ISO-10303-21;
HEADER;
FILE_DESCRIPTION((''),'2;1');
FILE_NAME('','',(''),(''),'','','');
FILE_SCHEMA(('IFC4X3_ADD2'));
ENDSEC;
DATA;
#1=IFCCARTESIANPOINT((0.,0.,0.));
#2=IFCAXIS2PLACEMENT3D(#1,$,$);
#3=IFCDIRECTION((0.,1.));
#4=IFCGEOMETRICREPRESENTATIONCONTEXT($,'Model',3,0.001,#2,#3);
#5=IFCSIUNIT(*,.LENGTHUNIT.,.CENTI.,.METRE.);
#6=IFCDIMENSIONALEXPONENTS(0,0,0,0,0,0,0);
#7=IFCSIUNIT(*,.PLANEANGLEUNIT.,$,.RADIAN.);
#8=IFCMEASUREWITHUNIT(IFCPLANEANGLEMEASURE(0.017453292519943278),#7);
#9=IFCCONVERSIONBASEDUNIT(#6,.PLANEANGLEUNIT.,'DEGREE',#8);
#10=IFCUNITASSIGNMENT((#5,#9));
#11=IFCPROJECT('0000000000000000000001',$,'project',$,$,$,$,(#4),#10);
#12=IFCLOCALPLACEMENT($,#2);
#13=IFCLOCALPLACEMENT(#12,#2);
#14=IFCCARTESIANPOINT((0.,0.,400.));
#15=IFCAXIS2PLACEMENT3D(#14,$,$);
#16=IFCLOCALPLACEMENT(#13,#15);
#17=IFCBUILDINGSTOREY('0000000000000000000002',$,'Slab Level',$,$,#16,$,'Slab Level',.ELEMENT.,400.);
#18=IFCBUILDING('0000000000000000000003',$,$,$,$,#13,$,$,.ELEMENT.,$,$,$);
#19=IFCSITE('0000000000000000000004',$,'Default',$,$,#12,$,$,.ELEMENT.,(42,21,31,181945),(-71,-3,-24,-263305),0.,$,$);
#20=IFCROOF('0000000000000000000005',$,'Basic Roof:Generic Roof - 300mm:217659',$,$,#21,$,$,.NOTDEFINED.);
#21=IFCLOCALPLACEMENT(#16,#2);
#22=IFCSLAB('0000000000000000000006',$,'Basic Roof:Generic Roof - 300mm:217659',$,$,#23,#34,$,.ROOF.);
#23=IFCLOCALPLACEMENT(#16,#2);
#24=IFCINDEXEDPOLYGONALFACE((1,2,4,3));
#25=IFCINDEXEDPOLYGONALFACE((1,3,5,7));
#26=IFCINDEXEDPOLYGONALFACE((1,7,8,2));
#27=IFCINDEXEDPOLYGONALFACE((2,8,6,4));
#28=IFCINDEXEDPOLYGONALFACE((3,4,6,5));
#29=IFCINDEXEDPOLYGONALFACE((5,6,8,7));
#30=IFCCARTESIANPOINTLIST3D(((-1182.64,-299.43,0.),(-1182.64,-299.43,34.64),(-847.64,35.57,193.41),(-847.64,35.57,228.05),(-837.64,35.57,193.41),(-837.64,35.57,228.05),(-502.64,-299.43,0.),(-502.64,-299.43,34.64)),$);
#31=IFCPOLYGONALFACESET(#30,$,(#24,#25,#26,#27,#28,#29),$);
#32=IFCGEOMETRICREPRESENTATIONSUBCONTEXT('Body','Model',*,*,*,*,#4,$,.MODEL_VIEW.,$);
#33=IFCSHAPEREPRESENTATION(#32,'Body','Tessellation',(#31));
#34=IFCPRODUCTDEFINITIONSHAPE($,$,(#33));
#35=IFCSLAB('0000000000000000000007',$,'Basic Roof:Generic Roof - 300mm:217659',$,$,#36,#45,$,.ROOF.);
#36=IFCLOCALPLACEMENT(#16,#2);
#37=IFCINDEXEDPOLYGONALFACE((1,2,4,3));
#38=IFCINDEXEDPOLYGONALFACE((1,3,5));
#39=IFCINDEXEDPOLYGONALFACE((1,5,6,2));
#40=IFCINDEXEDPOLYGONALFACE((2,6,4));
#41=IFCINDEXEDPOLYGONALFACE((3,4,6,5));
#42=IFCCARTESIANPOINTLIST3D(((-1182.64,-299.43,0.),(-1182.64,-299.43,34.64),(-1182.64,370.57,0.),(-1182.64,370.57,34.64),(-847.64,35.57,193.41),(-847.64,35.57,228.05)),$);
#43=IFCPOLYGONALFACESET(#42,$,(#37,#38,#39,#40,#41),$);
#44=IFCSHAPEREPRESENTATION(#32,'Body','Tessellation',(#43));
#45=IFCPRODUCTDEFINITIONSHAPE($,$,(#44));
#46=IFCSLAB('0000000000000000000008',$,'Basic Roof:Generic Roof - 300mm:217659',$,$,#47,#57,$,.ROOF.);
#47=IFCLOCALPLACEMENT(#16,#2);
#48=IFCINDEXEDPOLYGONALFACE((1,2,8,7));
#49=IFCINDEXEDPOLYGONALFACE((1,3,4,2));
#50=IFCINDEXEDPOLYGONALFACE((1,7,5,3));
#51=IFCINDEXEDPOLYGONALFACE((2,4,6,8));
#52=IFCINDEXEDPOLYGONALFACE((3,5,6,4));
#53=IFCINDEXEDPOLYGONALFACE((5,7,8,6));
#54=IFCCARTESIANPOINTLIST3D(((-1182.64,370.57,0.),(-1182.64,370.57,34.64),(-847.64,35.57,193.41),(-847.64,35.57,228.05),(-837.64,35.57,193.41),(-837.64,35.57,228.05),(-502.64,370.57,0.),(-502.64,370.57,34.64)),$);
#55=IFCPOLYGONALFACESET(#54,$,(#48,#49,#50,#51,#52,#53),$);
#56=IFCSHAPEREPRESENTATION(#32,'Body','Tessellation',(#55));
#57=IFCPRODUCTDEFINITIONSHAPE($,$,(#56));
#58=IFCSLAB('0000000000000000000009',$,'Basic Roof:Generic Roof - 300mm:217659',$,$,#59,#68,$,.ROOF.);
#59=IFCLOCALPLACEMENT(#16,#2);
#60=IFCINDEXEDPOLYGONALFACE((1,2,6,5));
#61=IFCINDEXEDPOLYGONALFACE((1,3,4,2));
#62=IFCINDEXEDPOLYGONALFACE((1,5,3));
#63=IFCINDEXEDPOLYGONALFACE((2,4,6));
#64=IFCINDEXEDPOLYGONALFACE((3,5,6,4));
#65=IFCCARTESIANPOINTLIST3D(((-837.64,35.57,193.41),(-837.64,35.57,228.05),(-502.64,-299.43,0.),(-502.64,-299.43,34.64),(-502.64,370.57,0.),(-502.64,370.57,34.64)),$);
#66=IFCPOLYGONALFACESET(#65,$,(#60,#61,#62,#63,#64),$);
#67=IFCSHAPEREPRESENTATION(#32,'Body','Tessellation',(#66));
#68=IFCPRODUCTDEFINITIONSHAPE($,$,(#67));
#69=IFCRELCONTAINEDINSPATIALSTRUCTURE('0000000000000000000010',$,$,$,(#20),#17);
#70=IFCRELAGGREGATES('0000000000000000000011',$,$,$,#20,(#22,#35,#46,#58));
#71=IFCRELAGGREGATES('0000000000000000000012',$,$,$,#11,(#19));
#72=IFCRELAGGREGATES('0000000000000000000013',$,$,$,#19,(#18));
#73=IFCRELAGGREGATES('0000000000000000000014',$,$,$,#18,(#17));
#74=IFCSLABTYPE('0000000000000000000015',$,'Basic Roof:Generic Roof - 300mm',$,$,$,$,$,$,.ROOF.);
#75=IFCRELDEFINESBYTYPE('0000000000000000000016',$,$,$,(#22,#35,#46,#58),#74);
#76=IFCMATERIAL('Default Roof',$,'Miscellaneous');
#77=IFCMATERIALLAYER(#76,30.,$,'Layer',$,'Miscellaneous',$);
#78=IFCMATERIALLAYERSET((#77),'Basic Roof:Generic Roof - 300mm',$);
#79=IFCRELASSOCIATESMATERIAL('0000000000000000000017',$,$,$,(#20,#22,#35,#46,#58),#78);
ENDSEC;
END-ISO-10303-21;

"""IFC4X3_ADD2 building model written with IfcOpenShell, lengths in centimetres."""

from ifc_helpers import new_model, entity, si_unit, converted_unit, direction, frame, origin, place, context, subcontext, project, spatial, polyline, outline, extrude, material, layer, layer_set, type_object, element, aggregate, save


model = new_model("IFC4X3_ADD2")

# Units and contexts
model_context = context("Model", 3, precision=0.001, world=origin(), true_north=direction((0.0, 1.0)))
body_context = subcontext(model_context, "Body", "Model", "MODEL_VIEW")
ifc_project = project(units=[si_unit("LENGTHUNIT", "METRE", prefix="CENTI"), converted_unit("PLANEANGLEUNIT", "DEGREE", entity("IfcPlaneAngleMeasure", 0.017453292519943278), si_unit("PLANEANGLEUNIT", "RADIAN"), dimensions=[0, 0, 0, 0, 0, 0, 0])], contexts=[model_context])

# Site, building, storey
site_placement = place(None, origin())
site = spatial("IfcSite", under=ifc_project, at=site_placement, Name="Default", CompositionType="ELEMENT", RefLatitude=(42, 21, 31, 181945), RefLongitude=(-71, -3, -24, -263305), RefElevation=0.0)
building_placement = place(site_placement, origin())
building = spatial("IfcBuilding", under=site, at=building_placement, CompositionType="ELEMENT")
storey_placement = place(building_placement, frame((0.0, 0.0, 400.0)))
storey = spatial("IfcBuildingStorey", under=building, at=storey_placement, Name="Slab Level", LongName="Slab Level", CompositionType="ELEMENT", Elevation=400.0)

# Roof, slabs
ifc_material = material(Name="Default Roof", Category="Miscellaneous")
ifc_layer = layer(ifc_material, 30.0, Name="Layer", Category="Miscellaneous")
ifc_layer_set = layer_set([ifc_layer], Name="Basic Roof:Generic Roof - 300mm")
roof_placement = place(storey_placement, frame((-1182.64, -299.43, 0.0)))
roof = element("IfcRoof", 1, at=roof_placement, inside=storey, material=ifc_layer_set, Name="Basic Roof:Generic Roof - 300mm:217659", PredefinedType="NOTDEFINED")
slab_type = type_object("IfcSlabType", Name="Basic Roof:Generic Roof - 300mm", PredefinedType="ROOF")
slab_1_placement = place(roof_placement, origin())
slab_1 = element("IfcSlab", 2, at=slab_1_placement, type_object=slab_type, material=ifc_layer_set, Name="Basic Roof:Generic Roof - 300mm:217659", PredefinedType="ROOF", context=body_context, shape_type="SweptSolid", body=[
    extrude(outline(polyline([(5.0, 193.41), (-5.0, 193.41), (-340.0, -193.41), (340.0, -193.41), (5.0, 193.41)])), frame((340.0, 167.5, 96.71), z_axis=(0.0, -0.5, 0.866025), x_axis=(1.0, 0.0, 0.0)), (0.0, 0.5, 0.866025), 34.64),
])
slab_2_placement = place(roof_placement, origin())
slab_2 = element("IfcSlab", 3, at=slab_2_placement, type_object=slab_type, material=ifc_layer_set, Name="Basic Roof:Generic Roof - 300mm:217659", PredefinedType="ROOF", context=body_context, shape_type="SweptSolid", body=[
    extrude(outline(polyline([(-193.41, 335.0), (-193.41, -335.0), (193.41, 0.0), (-193.41, 335.0)])), frame((167.5, 335.0, 96.71), z_axis=(-0.5, 0.0, 0.866025), x_axis=(0.866025, 0.0, 0.5)), (0.5, 0.0, 0.866025), 34.64),
])
slab_3_placement = place(roof_placement, origin())
slab_3 = element("IfcSlab", 4, at=slab_3_placement, type_object=slab_type, material=ifc_layer_set, Name="Basic Roof:Generic Roof - 300mm:217659", PredefinedType="ROOF", context=body_context, shape_type="SweptSolid", body=[
    extrude(outline(polyline([(340.0, 193.41), (-340.0, 193.41), (-5.0, -193.41), (5.0, -193.41), (340.0, 193.41)])), frame((340.0, 502.5, 96.71), z_axis=(0.0, 0.5, 0.866025), x_axis=(1.0, 0.0, 0.0)), (0.0, -0.5, 0.866025), 34.64),
])
slab_4_placement = place(roof_placement, origin())
slab_4 = element("IfcSlab", 5, at=slab_4_placement, type_object=slab_type, material=ifc_layer_set, Name="Basic Roof:Generic Roof - 300mm:217659", PredefinedType="ROOF", context=body_context, shape_type="SweptSolid", body=[
    extrude(outline(polyline([(193.41, -335.0), (193.41, 335.0), (-193.41, 0.0), (193.41, -335.0)])), frame((512.5, 335.0, 96.71), z_axis=(0.5, 0.0, 0.866025), x_axis=(0.866025, 0.0, -0.5)), (-0.5, 0.0, 0.866025), 34.64),
])
aggregate(roof, [slab_1, slab_2, slab_3, slab_4])

save(model, "model.ifc")
